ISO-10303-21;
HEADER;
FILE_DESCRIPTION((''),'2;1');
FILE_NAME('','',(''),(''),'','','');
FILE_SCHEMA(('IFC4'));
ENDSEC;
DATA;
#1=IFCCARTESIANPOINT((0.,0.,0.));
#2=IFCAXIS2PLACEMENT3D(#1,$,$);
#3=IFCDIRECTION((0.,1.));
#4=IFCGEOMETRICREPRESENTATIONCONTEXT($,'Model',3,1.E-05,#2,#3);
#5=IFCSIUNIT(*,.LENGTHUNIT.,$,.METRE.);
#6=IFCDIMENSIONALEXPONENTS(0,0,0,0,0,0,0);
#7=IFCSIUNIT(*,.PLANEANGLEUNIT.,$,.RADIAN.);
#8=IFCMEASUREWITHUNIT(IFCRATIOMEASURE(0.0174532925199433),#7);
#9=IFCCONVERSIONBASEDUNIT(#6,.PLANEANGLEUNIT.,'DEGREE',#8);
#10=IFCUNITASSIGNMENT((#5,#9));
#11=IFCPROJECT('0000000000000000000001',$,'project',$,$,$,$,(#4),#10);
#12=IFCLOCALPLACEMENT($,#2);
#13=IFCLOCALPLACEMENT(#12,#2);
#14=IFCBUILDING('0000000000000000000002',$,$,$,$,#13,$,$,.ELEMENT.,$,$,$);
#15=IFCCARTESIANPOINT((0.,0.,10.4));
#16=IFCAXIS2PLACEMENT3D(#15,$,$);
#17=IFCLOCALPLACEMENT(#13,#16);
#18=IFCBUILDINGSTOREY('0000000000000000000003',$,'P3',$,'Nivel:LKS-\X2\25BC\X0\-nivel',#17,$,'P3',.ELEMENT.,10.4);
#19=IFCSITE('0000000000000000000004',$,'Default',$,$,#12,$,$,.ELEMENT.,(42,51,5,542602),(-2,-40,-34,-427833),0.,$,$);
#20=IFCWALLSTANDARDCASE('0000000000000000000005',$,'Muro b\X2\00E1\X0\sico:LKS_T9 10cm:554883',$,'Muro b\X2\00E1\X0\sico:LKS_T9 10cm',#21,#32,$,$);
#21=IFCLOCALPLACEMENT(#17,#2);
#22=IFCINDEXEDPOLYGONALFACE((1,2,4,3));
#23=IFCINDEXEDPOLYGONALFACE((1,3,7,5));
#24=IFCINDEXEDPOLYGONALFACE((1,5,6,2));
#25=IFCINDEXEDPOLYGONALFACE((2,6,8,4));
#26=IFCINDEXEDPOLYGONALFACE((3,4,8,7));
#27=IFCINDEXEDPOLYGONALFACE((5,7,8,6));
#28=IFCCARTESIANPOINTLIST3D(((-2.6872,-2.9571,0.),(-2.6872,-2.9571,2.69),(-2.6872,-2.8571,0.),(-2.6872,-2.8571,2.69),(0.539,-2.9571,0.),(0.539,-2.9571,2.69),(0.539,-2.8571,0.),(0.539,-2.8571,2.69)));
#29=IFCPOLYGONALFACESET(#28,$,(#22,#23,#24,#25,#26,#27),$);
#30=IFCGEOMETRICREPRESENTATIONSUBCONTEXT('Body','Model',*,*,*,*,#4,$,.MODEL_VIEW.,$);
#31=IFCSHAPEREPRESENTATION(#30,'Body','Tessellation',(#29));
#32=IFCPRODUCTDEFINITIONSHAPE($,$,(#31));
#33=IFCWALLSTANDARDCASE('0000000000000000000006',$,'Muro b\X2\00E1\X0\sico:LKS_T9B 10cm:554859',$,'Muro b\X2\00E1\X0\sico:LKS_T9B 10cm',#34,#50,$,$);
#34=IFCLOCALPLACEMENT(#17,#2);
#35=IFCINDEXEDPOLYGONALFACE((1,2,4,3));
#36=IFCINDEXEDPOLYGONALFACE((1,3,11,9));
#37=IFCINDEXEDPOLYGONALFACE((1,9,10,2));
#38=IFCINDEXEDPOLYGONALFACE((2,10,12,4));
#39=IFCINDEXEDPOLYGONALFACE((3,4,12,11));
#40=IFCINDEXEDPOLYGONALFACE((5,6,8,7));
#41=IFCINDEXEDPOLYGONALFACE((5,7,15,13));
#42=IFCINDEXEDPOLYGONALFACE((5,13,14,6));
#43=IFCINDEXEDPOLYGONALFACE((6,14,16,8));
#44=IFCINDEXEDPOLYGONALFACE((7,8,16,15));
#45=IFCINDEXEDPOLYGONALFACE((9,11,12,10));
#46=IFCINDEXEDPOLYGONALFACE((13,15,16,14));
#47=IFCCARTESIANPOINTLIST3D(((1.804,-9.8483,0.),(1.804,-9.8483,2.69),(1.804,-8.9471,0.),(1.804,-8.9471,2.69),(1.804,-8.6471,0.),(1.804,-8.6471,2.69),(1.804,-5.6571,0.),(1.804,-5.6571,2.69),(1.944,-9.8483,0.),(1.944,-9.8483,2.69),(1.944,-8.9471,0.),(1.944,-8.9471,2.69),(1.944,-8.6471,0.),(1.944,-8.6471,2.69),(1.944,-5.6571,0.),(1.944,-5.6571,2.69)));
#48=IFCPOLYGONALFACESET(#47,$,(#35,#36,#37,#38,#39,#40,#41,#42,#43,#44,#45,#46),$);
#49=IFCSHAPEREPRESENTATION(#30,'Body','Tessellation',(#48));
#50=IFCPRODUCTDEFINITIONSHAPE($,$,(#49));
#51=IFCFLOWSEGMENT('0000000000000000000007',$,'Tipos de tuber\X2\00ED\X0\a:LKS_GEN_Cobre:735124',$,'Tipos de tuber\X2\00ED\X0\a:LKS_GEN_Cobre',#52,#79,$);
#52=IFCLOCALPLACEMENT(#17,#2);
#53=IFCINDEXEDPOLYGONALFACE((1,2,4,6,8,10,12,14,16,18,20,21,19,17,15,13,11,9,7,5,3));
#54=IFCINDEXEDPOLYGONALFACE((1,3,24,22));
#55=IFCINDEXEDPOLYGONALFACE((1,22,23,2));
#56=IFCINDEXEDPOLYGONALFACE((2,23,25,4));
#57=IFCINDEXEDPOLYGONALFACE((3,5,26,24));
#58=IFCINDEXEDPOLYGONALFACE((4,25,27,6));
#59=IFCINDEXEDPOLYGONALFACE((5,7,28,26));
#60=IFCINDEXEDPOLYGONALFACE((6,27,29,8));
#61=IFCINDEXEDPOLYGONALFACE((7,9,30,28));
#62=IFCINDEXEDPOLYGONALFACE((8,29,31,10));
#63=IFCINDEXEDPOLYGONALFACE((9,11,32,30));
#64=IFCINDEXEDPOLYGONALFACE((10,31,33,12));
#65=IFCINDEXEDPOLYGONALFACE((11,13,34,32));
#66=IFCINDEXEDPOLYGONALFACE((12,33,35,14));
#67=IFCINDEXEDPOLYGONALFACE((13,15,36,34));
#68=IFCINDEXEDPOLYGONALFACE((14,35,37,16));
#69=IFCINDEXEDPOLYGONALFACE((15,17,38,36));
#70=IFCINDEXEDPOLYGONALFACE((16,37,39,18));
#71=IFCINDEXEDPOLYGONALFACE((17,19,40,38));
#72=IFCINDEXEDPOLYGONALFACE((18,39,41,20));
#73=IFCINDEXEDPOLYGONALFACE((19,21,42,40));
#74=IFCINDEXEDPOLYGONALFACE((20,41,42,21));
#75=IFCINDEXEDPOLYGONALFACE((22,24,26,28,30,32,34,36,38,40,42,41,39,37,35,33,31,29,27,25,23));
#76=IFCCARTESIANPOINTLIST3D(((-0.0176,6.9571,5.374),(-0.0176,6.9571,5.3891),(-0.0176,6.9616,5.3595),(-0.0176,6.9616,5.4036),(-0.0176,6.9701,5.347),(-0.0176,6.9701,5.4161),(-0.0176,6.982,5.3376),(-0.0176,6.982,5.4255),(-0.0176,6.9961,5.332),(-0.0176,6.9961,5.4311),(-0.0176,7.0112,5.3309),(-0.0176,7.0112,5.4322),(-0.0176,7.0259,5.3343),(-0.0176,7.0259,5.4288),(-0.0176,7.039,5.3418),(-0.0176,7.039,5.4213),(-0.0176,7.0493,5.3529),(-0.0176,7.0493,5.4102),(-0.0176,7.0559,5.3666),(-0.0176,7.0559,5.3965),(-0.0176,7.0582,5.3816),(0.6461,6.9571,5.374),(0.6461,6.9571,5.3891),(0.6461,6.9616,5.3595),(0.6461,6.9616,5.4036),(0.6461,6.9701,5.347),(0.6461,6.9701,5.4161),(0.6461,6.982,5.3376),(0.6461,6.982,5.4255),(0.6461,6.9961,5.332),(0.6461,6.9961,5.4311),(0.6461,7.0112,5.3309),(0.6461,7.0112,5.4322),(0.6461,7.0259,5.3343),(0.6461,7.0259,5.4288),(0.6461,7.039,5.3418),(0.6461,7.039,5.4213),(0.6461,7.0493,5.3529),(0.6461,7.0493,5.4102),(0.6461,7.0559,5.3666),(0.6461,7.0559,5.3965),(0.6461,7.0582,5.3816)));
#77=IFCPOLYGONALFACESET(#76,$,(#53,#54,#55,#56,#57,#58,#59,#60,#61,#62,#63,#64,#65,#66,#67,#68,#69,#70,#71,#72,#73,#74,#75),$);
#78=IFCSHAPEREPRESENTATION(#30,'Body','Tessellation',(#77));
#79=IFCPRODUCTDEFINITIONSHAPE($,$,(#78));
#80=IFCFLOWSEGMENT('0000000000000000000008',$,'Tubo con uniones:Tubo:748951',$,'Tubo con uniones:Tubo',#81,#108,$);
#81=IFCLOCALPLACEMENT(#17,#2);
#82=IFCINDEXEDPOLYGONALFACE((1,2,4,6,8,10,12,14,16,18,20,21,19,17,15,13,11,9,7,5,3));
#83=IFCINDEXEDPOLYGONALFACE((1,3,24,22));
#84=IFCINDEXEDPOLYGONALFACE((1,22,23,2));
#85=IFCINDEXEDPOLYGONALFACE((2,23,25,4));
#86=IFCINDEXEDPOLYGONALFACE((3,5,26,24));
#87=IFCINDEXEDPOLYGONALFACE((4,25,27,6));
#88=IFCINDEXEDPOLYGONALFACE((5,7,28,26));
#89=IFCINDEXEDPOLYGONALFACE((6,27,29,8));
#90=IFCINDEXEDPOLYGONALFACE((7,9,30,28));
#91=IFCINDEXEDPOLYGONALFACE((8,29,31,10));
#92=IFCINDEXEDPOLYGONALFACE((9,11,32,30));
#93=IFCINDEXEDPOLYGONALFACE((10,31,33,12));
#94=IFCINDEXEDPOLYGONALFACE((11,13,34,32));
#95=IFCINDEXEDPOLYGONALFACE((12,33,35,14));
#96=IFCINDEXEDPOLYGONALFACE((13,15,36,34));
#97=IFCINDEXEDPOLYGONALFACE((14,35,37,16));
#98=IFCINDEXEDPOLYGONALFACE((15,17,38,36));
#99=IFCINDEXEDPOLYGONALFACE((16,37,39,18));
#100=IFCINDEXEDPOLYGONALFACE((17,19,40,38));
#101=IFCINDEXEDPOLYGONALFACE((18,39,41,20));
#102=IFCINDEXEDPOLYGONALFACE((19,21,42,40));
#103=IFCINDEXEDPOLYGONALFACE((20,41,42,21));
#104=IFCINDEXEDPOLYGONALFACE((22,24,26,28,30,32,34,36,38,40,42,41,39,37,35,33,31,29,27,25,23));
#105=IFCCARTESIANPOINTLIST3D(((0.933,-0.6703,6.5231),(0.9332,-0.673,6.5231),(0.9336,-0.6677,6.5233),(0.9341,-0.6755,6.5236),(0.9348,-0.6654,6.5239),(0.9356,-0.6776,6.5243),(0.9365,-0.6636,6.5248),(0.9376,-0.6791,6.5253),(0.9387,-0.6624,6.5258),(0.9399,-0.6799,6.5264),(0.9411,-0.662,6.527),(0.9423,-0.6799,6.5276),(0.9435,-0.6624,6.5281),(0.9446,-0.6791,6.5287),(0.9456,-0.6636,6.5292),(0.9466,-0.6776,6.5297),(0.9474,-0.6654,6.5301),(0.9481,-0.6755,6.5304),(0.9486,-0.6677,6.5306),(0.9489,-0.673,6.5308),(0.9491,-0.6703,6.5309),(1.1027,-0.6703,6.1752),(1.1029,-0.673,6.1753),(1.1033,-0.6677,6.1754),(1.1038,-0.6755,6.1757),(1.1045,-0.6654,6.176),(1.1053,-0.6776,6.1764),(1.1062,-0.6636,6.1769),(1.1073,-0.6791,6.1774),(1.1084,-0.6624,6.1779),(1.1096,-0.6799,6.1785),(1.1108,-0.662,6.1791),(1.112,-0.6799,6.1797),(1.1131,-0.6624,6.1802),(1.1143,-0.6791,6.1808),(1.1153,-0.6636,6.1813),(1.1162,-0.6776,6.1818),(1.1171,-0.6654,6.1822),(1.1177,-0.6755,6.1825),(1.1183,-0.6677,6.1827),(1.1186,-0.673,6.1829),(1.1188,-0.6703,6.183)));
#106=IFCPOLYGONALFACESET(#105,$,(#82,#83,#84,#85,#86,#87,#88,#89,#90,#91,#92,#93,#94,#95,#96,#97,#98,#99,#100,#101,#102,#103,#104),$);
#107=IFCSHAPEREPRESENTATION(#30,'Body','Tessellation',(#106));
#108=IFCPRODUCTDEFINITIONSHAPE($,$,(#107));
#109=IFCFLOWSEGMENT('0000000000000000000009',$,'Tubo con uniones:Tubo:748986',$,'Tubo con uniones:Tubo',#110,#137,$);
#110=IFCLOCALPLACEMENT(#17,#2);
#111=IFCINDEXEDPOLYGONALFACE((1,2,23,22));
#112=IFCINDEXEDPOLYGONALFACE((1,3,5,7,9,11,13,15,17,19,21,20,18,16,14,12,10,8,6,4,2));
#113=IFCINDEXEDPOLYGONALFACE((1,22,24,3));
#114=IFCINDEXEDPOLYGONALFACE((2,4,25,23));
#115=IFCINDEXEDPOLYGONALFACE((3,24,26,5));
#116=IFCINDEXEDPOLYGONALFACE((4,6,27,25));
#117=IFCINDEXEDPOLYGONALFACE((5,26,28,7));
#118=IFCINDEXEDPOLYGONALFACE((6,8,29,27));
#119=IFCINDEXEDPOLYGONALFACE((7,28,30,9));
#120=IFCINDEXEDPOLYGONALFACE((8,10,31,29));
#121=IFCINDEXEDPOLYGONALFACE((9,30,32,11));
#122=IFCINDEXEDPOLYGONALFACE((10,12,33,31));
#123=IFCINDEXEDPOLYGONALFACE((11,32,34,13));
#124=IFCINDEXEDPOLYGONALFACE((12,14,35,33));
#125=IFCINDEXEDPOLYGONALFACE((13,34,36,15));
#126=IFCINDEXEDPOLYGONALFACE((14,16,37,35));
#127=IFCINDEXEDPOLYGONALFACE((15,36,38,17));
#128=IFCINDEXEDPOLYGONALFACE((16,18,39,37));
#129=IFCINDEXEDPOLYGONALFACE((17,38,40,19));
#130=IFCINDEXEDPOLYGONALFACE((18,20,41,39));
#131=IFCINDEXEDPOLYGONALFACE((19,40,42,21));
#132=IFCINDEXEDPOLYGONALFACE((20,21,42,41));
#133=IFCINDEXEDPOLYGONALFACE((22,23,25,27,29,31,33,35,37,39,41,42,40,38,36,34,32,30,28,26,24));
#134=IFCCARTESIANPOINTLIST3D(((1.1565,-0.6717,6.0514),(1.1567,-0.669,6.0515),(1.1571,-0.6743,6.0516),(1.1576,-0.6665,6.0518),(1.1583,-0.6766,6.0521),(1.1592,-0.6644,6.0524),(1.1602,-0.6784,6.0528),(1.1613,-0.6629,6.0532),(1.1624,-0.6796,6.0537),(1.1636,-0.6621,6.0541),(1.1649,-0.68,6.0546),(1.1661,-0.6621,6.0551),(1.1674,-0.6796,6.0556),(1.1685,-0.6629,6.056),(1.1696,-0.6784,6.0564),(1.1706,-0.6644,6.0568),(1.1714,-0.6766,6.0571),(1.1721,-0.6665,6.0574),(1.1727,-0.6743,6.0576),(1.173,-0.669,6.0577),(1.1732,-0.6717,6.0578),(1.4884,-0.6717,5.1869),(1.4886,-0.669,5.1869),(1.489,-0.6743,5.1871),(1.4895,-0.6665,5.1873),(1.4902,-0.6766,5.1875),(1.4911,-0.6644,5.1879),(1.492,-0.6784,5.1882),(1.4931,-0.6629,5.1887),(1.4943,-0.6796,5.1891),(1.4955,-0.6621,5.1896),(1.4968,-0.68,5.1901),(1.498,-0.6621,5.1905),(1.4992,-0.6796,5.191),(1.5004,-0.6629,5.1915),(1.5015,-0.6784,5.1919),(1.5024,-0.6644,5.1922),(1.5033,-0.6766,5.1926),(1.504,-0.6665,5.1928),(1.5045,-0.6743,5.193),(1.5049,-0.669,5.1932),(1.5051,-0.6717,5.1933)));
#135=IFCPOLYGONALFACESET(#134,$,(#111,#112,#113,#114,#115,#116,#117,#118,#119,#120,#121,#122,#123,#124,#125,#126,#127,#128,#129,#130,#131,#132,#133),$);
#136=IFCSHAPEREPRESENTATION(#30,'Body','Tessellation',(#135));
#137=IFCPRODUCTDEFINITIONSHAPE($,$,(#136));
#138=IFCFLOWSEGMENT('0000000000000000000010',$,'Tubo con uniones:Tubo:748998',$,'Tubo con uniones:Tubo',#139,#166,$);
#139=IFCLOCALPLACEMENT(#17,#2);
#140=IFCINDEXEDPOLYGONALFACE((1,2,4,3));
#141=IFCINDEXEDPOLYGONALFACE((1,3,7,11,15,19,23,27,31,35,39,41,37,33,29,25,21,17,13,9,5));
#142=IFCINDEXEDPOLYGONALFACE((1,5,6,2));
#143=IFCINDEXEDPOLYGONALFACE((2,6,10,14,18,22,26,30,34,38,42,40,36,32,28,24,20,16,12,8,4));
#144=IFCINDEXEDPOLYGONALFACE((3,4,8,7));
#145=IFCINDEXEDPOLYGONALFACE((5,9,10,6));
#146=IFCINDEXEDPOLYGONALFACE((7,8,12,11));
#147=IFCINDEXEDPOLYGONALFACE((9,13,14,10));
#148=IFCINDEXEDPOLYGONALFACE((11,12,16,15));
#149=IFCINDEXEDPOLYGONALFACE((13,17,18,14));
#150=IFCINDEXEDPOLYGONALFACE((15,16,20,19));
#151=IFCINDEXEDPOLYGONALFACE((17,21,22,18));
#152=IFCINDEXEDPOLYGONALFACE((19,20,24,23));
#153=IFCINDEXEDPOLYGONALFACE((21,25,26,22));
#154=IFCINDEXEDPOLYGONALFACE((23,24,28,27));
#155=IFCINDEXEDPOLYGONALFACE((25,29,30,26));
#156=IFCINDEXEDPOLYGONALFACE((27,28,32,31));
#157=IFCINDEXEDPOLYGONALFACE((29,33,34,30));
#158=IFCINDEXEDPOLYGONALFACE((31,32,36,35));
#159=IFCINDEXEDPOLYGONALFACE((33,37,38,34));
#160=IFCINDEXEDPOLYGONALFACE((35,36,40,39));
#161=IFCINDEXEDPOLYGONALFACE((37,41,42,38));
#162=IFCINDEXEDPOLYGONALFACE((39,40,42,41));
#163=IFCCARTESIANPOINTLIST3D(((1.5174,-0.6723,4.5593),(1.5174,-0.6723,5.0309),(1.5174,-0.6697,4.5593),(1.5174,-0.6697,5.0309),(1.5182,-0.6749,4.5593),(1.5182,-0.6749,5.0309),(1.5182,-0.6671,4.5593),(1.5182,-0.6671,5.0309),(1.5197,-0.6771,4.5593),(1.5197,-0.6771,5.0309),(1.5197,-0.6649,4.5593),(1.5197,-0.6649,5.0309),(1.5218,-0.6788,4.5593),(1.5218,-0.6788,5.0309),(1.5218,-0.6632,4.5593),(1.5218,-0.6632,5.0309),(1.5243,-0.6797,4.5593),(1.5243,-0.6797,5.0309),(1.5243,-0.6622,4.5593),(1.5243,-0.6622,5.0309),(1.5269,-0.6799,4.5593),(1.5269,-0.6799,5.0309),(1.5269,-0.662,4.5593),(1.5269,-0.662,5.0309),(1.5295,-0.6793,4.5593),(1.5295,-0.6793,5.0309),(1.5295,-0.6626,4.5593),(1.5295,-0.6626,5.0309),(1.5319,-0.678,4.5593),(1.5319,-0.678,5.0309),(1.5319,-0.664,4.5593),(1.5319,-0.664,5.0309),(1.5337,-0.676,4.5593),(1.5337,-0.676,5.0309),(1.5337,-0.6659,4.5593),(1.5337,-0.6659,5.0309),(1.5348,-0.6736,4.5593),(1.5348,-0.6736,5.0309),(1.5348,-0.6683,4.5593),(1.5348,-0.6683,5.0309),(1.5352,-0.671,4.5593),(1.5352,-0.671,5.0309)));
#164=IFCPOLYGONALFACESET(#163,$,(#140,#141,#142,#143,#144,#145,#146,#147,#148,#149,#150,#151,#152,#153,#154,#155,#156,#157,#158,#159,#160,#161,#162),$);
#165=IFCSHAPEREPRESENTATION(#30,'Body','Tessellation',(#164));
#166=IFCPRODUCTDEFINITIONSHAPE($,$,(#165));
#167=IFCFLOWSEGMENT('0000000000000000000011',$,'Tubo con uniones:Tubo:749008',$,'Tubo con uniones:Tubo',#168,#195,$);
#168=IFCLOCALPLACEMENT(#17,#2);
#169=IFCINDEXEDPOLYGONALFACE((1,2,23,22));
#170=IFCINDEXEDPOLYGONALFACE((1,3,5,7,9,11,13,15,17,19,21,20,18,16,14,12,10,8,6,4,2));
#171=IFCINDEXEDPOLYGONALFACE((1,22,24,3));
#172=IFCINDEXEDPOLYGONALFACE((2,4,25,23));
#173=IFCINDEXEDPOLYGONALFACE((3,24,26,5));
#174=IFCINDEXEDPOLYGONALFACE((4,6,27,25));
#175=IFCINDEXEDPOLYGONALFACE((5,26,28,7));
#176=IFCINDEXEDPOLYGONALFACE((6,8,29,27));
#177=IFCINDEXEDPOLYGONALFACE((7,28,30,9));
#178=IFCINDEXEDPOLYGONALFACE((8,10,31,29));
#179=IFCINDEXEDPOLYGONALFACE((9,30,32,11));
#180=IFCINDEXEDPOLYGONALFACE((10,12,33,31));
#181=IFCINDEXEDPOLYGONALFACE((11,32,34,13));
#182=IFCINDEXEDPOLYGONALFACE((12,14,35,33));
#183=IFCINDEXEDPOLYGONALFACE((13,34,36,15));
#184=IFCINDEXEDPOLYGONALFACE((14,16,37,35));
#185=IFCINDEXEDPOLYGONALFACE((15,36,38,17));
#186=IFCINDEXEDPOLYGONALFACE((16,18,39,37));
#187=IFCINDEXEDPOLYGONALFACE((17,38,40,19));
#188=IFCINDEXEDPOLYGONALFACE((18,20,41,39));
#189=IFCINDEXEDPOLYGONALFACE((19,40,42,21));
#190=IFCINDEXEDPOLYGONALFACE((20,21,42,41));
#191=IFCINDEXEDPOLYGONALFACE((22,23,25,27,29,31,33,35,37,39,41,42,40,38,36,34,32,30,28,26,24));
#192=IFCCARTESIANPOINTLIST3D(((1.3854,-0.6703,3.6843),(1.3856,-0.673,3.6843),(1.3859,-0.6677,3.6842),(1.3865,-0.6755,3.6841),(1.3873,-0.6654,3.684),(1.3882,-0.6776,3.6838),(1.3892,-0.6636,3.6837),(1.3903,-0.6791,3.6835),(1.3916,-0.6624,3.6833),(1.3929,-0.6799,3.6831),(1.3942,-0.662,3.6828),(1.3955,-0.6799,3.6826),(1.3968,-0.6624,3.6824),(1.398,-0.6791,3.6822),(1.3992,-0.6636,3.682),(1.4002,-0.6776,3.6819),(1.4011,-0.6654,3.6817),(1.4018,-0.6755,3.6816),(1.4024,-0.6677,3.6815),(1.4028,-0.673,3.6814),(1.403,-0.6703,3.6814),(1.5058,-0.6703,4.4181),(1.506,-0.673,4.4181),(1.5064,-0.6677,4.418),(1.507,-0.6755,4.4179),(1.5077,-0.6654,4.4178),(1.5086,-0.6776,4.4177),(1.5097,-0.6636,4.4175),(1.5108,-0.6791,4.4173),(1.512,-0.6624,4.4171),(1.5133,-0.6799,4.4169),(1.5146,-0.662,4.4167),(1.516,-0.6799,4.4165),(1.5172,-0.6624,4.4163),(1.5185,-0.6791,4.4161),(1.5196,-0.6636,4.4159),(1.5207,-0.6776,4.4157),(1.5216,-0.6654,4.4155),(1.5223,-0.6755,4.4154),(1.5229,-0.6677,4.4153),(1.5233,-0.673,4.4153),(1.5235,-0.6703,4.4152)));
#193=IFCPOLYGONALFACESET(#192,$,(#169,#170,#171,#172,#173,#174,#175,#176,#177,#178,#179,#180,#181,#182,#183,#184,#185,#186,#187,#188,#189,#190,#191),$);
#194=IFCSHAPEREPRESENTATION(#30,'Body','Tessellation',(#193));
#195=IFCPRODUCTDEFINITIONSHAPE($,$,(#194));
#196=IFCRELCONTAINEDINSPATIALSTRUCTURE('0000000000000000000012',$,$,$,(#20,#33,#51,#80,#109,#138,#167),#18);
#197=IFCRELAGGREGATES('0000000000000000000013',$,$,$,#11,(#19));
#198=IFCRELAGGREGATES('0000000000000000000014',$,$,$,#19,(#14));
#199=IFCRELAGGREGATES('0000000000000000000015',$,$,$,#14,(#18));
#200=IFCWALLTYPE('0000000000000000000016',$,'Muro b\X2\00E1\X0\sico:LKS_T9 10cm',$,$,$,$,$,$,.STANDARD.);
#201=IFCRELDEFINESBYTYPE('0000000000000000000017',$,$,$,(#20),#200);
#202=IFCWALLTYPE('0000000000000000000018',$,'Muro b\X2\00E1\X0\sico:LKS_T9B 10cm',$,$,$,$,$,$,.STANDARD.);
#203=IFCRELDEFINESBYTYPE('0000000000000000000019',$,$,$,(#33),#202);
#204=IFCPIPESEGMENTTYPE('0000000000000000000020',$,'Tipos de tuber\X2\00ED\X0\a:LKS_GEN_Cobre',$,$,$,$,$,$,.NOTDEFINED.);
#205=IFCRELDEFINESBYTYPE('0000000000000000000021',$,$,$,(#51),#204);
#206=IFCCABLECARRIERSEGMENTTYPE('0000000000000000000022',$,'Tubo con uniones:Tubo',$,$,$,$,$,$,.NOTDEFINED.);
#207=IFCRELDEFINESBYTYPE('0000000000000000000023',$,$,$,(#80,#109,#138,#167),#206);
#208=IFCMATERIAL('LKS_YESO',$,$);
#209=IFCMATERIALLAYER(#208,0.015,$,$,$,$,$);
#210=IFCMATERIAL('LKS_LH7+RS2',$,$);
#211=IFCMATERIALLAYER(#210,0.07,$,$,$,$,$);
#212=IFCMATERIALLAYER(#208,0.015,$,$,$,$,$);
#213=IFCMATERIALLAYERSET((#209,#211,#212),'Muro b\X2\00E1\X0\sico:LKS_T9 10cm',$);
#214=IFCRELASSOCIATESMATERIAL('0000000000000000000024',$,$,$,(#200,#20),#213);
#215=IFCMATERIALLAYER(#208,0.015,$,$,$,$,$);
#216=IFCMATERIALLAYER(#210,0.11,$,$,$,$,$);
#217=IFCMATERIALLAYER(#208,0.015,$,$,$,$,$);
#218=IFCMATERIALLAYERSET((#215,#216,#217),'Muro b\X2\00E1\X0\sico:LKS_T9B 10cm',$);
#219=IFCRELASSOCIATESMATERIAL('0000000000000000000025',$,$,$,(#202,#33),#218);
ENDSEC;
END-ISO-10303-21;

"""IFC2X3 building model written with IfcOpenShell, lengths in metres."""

from ifc_helpers import new_model, entity, si_unit, converted_unit, direction, frame, frame_2d, origin, origin_2d_with_axis, place, context, subcontext, project, spatial, rectangle, circle, extrude, material, layer, layer_set, layer_usage, type_object, element, save


model = new_model("IFC2X3")

# Units and contexts
model_context = context("Model", 3, precision=1e-05, world=origin(), true_north=direction((0.0, 1.0)))
body_context = subcontext(model_context, "Body", "Model", "MODEL_VIEW")
ifc_project = project(units=[si_unit("LENGTHUNIT", "METRE"), converted_unit("PLANEANGLEUNIT", "DEGREE", entity("IfcRatioMeasure", 0.0174532925199433), si_unit("PLANEANGLEUNIT", "RADIAN"), dimensions=[0, 0, 0, 0, 0, 0, 0])], contexts=[model_context])

# Site, building, storey
site_placement = place(None, origin())
site = spatial("IfcSite", under=ifc_project, at=site_placement, Name="Default", CompositionType="ELEMENT", RefLatitude=(42, 51, 5, 542602), RefLongitude=(-2, -40, -34, -427833), RefElevation=0.0)
building_placement = place(site_placement, origin())
building = spatial("IfcBuilding", under=site, at=building_placement, CompositionType="ELEMENT")
storey_placement = place(building_placement, frame((0.0, 0.0, 10.4)))
storey = spatial("IfcBuildingStorey", under=building, at=storey_placement, Name="P3", ObjectType="Nivel:LKS-▼-nivel", LongName="P3", CompositionType="ELEMENT", Elevation=10.4)

# Shared definitions
ifc_material_1 = material(Name="LKS_LH7+RS2")
ifc_material_2 = material(Name="LKS_YESO")

# Shared definitions
ifc_layer_1 = layer(ifc_material_2, 0.015)
ifc_layer_2 = layer(ifc_material_1, 0.07)
ifc_layer_3 = layer(ifc_material_2, 0.015)
ifc_layer_set_1 = layer_set([ifc_layer_1, ifc_layer_2, ifc_layer_3], Name="Muro básico:LKS_T9 10cm")
wall_type_1 = type_object("IfcWallType", Name="Muro básico:LKS_T9 10cm", PredefinedType="STANDARD", material=ifc_layer_set_1)

# Wall
ifc_layer_usage_1 = layer_usage(ifc_layer_set_1, "AXIS2", "NEGATIVE", 0.05)
wall_1_placement = place(storey_placement, frame((-2.6872, -2.9071, 0.0)))
element("IfcWallStandardCase", 1, at=wall_1_placement, inside=storey, type_object=wall_type_1, material=ifc_layer_usage_1, Name="Muro básico:LKS_T9 10cm:554883", ObjectType="Muro básico:LKS_T9 10cm", context=body_context, shape_type="SweptSolid", body=[
    extrude(rectangle(XDim=3.2261, YDim=0.1, at=frame_2d((1.6131, 0.0), x_axis=(-1.0, 0.0))), origin(), (0.0, 0.0, 1.0), 2.69),
])

# Wall, opening
ifc_layer_4 = layer(ifc_material_2, 0.015)
ifc_layer_5 = layer(ifc_material_1, 0.11)
ifc_layer_6 = layer(ifc_material_2, 0.015)
ifc_layer_set_2 = layer_set([ifc_layer_4, ifc_layer_5, ifc_layer_6], Name="Muro básico:LKS_T9B 10cm")
ifc_layer_usage_2 = layer_usage(ifc_layer_set_2, "AXIS2", "NEGATIVE", 0.07)
wall_type_2 = type_object("IfcWallType", Name="Muro básico:LKS_T9B 10cm", PredefinedType="STANDARD", material=ifc_layer_set_2)
wall_2_placement = place(storey_placement, frame((1.874, -5.6571, 0.0), z_axis=(0.0, 0.0, 1.0), x_axis=(0.0, -1.0, 0.0)))
wall_2 = element("IfcWallStandardCase", 2, at=wall_2_placement, inside=storey, type_object=wall_type_2, material=ifc_layer_usage_2, Name="Muro básico:LKS_T9B 10cm:554859", ObjectType="Muro básico:LKS_T9B 10cm", context=body_context, shape_type="SweptSolid", body=[
    extrude(rectangle(XDim=4.1911, YDim=0.14, at=frame_2d((2.0956, 0.0), x_axis=(-1.0, 0.0))), origin(), (0.0, 0.0, 1.0), 2.69),
])
opening_1_placement = place(storey_placement, frame((1.874, -5.6571, 0.0), z_axis=(0.0, 0.0, 1.0), x_axis=(0.0, -1.0, 0.0)))
element("IfcOpeningElement", 3, at=opening_1_placement, cuts=wall_2, ObjectType="Opening", context=body_context, shape_type="SweptSolid", body=[
    extrude(rectangle(XDim=2.69, YDim=0.14, at=origin_2d_with_axis()), frame((3.29, 0.0, 1.345), z_axis=(-1.0, 0.0, 0.0), x_axis=(0.0, 0.0, 1.0)), (0.0, 0.0, 1.0), 0.3),
])

# Flow segments
pipe_segment_type = type_object("IfcPipeSegmentType", Name="Tipos de tubería:LKS_GEN_Cobre", PredefinedType="NOTDEFINED")
flow_segment_1_placement = place(storey_placement, origin())
element("IfcFlowSegment", 4, at=flow_segment_1_placement, inside=storey, type_object=pipe_segment_type, Name="Tipos de tubería:LKS_GEN_Cobre:735124", ObjectType="Tipos de tubería:LKS_GEN_Cobre", context=body_context, shape_type="SweptSolid", body=[
    extrude(circle(Radius=0.0508, at=frame_2d((0.0, 0.0), x_axis=(1.0, 0.0))), frame((-0.0176, 7.0074, 5.3816), z_axis=(1.0, 0.0, 0.0), x_axis=(0.0, 1.0, 0.0)), (0.0, 0.0, 1.0), 0.6637),
])
cable_carrier_segment_type = type_object("IfcCableCarrierSegmentType", Name="Tubo con uniones:Tubo", PredefinedType="NOTDEFINED")
flow_segment_2_placement = place(storey_placement, origin())
element("IfcFlowSegment", 5, at=flow_segment_2_placement, inside=storey, type_object=cable_carrier_segment_type, Name="Tubo con uniones:Tubo:748951", ObjectType="Tubo con uniones:Tubo", context=body_context, shape_type="SweptSolid", body=[
    extrude(circle(Radius=0.009, at=frame_2d((0.0, 0.0), x_axis=(1.0, 0.0))), frame((1.1108, -0.671, 6.1791), z_axis=(-0.438371, 0.0, 0.898794), x_axis=(0.0, 1.0, 0.0)), (0.0, 0.0, 1.0), 0.3871),
])
flow_segment_3_placement = place(storey_placement, origin())
element("IfcFlowSegment", 6, at=flow_segment_3_placement, inside=storey, type_object=cable_carrier_segment_type, Name="Tubo con uniones:Tubo:748986", ObjectType="Tubo con uniones:Tubo", context=body_context, shape_type="SweptSolid", body=[
    extrude(circle(Radius=0.009, at=origin_2d_with_axis()), frame((1.1649, -0.671, 6.0546), z_axis=(0.358368, 0.0, -0.93358), x_axis=(0.0, -1.0, 0.0)), (0.0, 0.0, 1.0), 0.9261),
])
flow_segment_4_placement = place(storey_placement, origin())
element("IfcFlowSegment", 7, at=flow_segment_4_placement, inside=storey, type_object=cable_carrier_segment_type, Name="Tubo con uniones:Tubo:748998", ObjectType="Tubo con uniones:Tubo", context=body_context, shape_type="SweptSolid", body=[
    extrude(circle(Radius=0.009, at=frame_2d((0.0, 0.0), x_axis=(1.0, 0.0))), frame((1.5263, -0.671, 4.5593)), (0.0, 0.0, 1.0), 0.4716),
])
flow_segment_5_placement = place(storey_placement, origin())
element("IfcFlowSegment", 8, at=flow_segment_5_placement, inside=storey, type_object=cable_carrier_segment_type, Name="Tubo con uniones:Tubo:749008", ObjectType="Tubo con uniones:Tubo", context=body_context, shape_type="SweptSolid", body=[
    extrude(circle(Radius=0.009, at=frame_2d((0.0, 0.0), x_axis=(1.0, 0.0))), frame((1.3942, -0.671, 3.6828), z_axis=(0.161971, 0.0, 0.986796), x_axis=(0.0, 1.0, 0.0)), (0.0, 0.0, 1.0), 0.7437),
])

save(model, "model.ifc")
